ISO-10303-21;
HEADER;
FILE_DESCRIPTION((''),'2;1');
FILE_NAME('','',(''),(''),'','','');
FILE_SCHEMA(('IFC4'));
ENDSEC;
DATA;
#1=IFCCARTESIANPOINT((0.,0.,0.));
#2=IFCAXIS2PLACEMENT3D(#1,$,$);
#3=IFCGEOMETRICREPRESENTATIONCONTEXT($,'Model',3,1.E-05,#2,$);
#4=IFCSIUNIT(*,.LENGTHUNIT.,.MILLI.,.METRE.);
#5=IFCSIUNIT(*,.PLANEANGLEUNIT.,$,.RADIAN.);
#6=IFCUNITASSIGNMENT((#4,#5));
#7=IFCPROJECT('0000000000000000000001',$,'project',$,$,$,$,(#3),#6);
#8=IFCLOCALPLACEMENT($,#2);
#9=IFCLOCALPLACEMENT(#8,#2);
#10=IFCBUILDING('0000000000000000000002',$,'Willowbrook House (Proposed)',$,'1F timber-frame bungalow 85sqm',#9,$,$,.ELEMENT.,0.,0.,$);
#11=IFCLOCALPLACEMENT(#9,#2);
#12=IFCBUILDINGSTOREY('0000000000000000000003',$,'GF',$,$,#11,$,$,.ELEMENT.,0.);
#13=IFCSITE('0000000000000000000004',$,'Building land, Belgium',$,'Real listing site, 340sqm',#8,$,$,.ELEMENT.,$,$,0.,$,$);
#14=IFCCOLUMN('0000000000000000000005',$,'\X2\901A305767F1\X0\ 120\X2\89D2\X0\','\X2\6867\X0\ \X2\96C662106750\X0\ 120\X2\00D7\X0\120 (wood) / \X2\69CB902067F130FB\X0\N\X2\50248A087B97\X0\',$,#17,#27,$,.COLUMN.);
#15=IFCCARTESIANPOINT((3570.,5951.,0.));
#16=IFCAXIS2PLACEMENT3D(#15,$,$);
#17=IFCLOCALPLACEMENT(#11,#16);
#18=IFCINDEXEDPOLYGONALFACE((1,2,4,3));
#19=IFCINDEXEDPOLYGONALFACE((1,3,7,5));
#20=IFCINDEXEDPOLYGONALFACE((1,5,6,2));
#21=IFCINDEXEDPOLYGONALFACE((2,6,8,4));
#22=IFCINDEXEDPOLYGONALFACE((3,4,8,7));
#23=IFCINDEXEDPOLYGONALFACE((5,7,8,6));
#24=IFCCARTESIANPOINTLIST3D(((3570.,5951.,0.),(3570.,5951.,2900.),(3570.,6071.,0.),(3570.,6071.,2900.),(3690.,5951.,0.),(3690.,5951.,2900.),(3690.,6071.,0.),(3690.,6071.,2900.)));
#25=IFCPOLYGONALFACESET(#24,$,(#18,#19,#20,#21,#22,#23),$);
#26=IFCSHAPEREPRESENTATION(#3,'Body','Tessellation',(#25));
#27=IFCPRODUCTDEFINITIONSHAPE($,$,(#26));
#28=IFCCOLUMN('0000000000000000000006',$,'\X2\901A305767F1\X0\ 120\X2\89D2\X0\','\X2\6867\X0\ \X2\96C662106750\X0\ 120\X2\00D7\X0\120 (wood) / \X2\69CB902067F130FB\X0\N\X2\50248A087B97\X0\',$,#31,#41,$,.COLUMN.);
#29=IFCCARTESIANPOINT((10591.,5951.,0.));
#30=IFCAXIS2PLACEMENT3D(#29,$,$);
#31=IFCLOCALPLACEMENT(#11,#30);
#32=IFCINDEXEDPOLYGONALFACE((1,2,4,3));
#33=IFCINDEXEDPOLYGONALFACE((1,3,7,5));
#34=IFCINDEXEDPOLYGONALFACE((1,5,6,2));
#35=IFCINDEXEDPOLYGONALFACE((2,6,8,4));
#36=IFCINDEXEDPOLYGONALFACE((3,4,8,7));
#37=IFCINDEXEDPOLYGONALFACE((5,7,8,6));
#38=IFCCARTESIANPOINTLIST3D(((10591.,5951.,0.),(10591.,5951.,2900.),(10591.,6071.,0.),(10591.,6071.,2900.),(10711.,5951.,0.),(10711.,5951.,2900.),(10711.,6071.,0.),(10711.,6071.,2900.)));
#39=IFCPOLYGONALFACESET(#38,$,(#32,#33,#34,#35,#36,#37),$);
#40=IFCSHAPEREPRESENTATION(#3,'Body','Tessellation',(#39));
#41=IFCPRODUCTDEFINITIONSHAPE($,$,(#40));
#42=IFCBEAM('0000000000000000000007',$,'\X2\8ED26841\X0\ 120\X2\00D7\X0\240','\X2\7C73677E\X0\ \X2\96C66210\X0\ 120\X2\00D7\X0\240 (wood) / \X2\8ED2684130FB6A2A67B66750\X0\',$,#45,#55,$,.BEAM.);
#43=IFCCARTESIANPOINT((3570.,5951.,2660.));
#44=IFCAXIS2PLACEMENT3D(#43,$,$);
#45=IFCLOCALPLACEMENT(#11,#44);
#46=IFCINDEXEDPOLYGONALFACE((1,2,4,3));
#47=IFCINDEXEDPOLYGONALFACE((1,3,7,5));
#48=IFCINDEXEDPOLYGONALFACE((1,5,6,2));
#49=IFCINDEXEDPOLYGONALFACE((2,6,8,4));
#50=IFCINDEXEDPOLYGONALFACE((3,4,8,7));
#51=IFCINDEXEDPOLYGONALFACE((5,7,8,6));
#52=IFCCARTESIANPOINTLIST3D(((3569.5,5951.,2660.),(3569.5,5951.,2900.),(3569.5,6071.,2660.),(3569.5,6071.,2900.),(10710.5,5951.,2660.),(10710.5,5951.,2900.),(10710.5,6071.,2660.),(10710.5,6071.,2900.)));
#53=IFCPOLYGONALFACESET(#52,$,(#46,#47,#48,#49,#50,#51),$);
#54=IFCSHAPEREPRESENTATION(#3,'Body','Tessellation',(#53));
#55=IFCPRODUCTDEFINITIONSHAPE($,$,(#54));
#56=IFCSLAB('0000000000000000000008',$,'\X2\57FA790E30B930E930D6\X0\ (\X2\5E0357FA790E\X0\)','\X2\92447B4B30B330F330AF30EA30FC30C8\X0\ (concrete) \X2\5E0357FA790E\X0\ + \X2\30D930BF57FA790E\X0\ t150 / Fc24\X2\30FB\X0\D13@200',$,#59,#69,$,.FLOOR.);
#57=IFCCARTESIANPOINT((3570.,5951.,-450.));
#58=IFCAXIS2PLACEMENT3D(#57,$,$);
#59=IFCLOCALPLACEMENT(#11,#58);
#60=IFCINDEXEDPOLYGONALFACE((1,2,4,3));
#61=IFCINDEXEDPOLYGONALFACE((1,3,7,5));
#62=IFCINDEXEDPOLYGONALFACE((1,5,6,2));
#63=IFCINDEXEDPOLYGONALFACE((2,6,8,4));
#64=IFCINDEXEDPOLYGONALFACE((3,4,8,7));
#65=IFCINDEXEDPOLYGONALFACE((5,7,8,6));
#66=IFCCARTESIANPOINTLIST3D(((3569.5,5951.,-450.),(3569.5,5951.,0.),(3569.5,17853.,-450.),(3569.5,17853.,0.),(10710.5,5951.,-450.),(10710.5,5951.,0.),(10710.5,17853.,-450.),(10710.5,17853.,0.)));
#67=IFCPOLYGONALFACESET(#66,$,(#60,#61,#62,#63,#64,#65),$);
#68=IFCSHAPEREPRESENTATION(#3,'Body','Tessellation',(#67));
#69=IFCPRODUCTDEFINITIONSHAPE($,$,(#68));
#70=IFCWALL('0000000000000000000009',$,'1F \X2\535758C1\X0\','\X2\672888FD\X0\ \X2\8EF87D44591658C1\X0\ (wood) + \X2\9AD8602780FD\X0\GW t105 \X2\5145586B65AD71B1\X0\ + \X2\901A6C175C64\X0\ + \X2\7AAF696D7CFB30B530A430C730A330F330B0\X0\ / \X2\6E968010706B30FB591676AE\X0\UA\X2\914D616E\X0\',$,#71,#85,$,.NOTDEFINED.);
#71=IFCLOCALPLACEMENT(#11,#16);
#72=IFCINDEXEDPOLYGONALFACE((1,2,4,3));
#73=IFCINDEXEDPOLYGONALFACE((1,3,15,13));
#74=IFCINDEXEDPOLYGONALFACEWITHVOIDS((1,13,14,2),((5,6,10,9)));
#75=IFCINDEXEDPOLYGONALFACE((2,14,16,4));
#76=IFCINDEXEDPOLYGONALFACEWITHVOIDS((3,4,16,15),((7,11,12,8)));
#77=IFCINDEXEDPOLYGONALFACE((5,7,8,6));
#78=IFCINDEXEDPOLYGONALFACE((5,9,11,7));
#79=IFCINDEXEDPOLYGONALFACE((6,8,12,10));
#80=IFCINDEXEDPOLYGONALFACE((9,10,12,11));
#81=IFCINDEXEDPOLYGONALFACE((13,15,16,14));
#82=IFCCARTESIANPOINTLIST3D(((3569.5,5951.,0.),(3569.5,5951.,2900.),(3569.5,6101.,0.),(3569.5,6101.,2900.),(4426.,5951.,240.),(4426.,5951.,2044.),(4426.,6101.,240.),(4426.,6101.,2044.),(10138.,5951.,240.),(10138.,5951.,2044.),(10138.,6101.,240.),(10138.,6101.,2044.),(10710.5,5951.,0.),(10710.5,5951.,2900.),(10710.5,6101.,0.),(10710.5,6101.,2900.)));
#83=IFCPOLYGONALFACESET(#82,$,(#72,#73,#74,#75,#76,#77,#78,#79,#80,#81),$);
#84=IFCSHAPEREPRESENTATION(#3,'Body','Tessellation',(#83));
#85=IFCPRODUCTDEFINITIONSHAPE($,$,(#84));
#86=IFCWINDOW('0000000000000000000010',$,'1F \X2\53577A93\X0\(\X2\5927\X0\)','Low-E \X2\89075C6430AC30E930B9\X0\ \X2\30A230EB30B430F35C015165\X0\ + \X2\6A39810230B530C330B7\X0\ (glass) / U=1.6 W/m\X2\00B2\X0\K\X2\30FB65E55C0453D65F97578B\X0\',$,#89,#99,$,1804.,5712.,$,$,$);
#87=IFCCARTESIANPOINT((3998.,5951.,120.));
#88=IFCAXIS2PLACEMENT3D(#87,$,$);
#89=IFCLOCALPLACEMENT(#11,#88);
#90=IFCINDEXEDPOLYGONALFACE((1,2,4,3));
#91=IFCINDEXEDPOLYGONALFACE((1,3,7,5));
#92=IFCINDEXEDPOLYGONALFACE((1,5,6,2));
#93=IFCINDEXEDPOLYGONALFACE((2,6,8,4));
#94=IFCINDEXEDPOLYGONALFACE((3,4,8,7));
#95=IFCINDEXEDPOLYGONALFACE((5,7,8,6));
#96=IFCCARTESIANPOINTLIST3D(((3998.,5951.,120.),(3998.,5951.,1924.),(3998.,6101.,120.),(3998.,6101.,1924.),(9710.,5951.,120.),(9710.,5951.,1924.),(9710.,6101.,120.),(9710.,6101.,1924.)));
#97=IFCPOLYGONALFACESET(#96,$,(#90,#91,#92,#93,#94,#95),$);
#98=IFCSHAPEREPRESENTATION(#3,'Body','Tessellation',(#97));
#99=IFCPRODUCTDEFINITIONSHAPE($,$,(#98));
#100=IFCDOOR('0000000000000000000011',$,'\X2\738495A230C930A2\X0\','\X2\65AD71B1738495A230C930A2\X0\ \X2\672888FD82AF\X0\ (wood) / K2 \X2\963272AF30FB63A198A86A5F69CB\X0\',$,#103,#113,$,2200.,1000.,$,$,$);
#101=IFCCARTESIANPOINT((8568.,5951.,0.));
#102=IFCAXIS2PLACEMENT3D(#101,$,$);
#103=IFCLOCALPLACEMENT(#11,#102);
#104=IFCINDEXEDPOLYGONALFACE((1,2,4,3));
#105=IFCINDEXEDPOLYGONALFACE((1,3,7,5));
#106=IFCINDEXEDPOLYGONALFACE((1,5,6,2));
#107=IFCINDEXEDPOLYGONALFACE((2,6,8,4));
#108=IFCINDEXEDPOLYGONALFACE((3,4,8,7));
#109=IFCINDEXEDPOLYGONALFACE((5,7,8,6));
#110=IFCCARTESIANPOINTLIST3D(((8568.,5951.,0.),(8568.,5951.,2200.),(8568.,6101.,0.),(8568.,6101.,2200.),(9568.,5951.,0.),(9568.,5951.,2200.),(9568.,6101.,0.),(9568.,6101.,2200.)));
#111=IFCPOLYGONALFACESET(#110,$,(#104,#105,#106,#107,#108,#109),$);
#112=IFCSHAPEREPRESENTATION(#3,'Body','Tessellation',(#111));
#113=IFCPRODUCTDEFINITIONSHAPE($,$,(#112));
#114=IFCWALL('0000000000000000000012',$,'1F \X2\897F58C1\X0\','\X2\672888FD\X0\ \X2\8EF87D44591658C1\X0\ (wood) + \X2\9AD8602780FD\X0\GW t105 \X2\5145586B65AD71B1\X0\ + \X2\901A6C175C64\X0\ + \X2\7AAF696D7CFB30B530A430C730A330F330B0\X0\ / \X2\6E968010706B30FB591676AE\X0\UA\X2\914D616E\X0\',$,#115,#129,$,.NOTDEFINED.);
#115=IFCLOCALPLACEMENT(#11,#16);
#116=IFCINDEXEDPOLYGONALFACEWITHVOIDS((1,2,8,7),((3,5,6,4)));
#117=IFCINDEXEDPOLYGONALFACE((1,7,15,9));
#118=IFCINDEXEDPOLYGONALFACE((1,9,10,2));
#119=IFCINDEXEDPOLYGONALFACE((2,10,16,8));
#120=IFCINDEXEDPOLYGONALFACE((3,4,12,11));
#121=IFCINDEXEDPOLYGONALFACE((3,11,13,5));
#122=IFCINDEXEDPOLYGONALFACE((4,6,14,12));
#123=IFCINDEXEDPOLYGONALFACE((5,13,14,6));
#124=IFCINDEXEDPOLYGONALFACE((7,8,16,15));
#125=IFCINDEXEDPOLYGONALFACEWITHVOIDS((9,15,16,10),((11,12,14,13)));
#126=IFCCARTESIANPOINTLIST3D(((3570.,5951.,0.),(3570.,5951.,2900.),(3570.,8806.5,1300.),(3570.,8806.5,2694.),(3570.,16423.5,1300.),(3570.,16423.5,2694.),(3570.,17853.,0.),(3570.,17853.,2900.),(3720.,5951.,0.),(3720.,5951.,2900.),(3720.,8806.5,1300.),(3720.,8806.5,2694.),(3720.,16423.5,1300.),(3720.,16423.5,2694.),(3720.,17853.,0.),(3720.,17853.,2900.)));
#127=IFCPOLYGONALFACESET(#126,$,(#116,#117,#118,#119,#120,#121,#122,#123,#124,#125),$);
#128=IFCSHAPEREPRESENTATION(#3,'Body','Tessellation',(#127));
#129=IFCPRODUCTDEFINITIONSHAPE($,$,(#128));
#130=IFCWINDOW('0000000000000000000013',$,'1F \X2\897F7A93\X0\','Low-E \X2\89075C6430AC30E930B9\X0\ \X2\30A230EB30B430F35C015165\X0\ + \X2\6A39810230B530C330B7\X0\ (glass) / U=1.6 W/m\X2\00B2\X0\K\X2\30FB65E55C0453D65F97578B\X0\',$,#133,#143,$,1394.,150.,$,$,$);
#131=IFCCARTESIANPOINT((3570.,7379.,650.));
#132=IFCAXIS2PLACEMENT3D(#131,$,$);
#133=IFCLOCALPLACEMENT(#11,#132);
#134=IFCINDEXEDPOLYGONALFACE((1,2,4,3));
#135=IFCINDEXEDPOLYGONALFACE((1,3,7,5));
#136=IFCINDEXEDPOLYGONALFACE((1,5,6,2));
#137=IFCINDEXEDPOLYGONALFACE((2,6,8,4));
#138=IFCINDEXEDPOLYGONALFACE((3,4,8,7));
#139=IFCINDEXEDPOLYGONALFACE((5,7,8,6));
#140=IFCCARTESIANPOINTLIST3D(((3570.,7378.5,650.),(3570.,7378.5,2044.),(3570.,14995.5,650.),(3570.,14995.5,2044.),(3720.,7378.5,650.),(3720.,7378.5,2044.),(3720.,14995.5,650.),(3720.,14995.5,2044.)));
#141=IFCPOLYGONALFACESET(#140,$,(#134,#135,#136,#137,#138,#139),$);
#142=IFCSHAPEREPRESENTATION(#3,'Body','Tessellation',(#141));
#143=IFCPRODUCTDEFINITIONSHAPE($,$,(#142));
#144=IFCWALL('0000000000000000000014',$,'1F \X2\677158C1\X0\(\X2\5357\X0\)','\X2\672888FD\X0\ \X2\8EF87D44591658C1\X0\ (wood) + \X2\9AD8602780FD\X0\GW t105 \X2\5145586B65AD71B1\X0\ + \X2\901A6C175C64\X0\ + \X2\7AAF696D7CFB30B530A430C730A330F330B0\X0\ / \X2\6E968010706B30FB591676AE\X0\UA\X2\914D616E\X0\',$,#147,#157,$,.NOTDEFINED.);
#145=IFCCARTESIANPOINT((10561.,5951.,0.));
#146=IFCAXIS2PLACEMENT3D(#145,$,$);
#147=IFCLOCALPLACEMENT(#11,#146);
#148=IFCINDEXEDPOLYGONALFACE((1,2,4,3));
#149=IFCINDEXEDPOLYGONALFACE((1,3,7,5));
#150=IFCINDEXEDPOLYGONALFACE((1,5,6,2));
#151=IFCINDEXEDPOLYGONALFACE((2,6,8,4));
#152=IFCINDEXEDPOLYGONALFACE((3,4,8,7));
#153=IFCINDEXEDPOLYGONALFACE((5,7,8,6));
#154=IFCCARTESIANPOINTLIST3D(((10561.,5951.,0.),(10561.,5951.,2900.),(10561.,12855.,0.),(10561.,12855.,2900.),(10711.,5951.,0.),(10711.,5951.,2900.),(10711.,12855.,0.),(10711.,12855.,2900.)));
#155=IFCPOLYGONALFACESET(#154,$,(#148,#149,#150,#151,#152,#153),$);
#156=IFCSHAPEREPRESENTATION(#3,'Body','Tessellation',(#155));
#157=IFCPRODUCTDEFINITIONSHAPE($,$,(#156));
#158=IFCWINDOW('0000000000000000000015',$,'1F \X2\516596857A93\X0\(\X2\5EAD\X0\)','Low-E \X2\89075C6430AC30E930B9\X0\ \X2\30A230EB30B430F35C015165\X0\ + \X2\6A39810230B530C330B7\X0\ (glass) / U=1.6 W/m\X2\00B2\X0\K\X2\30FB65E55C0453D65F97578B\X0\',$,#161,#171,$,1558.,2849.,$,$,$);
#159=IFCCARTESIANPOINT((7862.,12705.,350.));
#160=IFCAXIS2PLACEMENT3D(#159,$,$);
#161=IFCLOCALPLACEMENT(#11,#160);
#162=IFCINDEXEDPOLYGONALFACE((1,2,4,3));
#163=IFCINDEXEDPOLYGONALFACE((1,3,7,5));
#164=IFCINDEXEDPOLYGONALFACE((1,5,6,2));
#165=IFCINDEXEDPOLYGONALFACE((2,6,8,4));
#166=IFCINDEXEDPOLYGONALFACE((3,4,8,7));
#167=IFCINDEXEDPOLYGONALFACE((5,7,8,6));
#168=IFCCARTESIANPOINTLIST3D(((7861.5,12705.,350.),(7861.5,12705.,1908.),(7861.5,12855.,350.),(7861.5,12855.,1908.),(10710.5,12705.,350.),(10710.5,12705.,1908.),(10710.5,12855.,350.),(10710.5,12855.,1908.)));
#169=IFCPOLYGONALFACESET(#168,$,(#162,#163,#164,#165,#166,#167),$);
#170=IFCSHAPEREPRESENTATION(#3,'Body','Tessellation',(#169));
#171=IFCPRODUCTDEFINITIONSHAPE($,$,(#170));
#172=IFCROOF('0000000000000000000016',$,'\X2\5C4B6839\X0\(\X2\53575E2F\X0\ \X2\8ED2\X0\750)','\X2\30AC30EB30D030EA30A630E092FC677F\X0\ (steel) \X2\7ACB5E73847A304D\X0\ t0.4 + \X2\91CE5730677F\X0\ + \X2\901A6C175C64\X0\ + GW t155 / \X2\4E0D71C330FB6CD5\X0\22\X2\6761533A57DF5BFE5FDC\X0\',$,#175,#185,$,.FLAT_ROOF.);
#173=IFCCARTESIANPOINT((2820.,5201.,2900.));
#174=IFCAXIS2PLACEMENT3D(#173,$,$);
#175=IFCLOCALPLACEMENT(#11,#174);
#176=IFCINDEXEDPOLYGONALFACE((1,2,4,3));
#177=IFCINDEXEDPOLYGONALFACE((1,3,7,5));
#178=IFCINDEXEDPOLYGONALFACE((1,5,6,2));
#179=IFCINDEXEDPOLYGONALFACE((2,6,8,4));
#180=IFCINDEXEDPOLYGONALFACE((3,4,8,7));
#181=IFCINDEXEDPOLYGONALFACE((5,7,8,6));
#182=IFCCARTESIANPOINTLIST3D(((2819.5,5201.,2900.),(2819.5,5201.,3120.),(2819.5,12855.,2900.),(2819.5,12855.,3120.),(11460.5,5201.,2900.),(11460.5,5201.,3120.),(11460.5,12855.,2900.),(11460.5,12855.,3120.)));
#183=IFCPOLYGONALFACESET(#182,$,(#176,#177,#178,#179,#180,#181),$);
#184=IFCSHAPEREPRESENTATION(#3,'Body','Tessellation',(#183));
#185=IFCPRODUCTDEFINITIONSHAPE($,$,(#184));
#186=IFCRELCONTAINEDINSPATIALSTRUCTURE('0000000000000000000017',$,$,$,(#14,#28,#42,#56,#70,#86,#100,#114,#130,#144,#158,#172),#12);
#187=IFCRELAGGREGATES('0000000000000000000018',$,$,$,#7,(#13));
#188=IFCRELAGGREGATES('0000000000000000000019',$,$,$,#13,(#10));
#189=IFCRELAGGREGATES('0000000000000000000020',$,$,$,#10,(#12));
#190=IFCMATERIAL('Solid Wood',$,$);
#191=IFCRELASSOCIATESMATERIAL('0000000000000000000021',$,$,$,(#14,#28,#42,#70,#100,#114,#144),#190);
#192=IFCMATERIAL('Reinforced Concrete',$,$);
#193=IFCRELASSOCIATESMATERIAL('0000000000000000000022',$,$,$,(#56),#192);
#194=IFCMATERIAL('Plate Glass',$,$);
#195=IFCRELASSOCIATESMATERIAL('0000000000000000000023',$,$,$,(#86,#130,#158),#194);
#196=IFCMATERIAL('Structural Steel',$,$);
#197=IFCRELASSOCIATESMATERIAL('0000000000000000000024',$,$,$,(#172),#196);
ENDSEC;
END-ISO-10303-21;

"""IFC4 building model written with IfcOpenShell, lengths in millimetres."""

from ifc_helpers import new_model, si_unit, frame, frame_2d, origin, place, context, project, spatial, rectangle, extrude, material, element, fill, save


model = new_model("IFC4")

# Units and contexts
model_context = context("Model", 3, precision=1e-05, world=origin())
ifc_project = project(units=[si_unit("LENGTHUNIT", "METRE", prefix="MILLI"), si_unit("PLANEANGLEUNIT", "RADIAN")], contexts=[model_context])

# Site, building, storey
site_placement = place(None, origin())
site = spatial("IfcSite", under=ifc_project, at=site_placement, Name="Building land, Belgium", ObjectType="Real listing site, 340sqm", CompositionType="ELEMENT", RefElevation=0.0)
building_placement = place(site_placement, origin())
building = spatial("IfcBuilding", under=site, at=building_placement, Name="Willowbrook House (Proposed)", ObjectType="1F timber-frame bungalow 85sqm", CompositionType="ELEMENT", ElevationOfRefHeight=0.0, ElevationOfTerrain=0.0)
storey_placement = place(building_placement, origin())
storey = spatial("IfcBuildingStorey", under=building, at=storey_placement, Name="GF", CompositionType="ELEMENT", Elevation=0.0)

# Columns
ifc_material_1 = material(Name="Solid Wood")
column_1_placement = place(storey_placement, frame((3570.0, 5951.0, 0.0)))
element("IfcColumn", 1, at=column_1_placement, inside=storey, material=ifc_material_1, Name="通し柱 120角", Description="桧 集成材 120×120 (wood) / 構造柱・N値計算", PredefinedType="COLUMN", context=model_context, shape_type="SweptSolid", body=[
    extrude(rectangle(XDim=120.0, YDim=120.0, at=frame_2d((60.0, 60.0))), frame((3570.0, 5951.0, 0.0)), (0.0, 0.0, 1.0), 2900.0),
])
column_2_placement = place(storey_placement, frame((10591.0, 5951.0, 0.0)))
element("IfcColumn", 2, at=column_2_placement, inside=storey, material=ifc_material_1, Name="通し柱 120角", Description="桧 集成材 120×120 (wood) / 構造柱・N値計算", PredefinedType="COLUMN", context=model_context, shape_type="SweptSolid", body=[
    extrude(rectangle(XDim=120.0, YDim=120.0, at=frame_2d((60.0, 60.0))), frame((10591.0, 5951.0, 0.0)), (0.0, 0.0, 1.0), 2900.0),
])

# Beam
beam_1_placement = place(storey_placement, frame((3570.0, 5951.0, 2660.0)))
element("IfcBeam", 3, at=beam_1_placement, inside=storey, material=ifc_material_1, Name="軒桁 120×240", Description="米松 集成 120×240 (wood) / 軒桁・横架材", PredefinedType="BEAM", context=model_context, shape_type="SweptSolid", body=[
    extrude(rectangle(XDim=7141.0, YDim=120.0, at=frame_2d((3570.0, 60.0))), frame((3570.0, 5951.0, 2660.0)), (0.0, 0.0, 1.0), 240.0),
])

# Slab
ifc_material_2 = material(Name="Reinforced Concrete")
slab_1_placement = place(storey_placement, frame((3570.0, 5951.0, -450.0)))
element("IfcSlab", 4, at=slab_1_placement, inside=storey, material=ifc_material_2, Name="基礎スラブ (布基礎)", Description="鉄筋コンクリート (concrete) 布基礎 + ベタ基礎 t150 / Fc24・D13@200", PredefinedType="FLOOR", context=model_context, shape_type="SweptSolid", body=[
    extrude(rectangle(XDim=7141.0, YDim=11902.0, at=frame_2d((3570.0, 5951.0))), frame((3570.0, 5951.0, -450.0)), (0.0, 0.0, 1.0), 450.0),
])

# Wall, openings, window, door
wall_1_placement = place(storey_placement, frame((3570.0, 5951.0, 0.0)))
wall_1 = element("IfcWall", 5, at=wall_1_placement, inside=storey, material=ifc_material_1, Name="1F 南壁", Description="木製 軸組外壁 (wood) + 高性能GW t105 充填断熱 + 通気層 + 窯業系サイディング / 準耐火・外皮UA配慮", PredefinedType="NOTDEFINED", context=model_context, shape_type="SweptSolid", body=[
    extrude(rectangle(XDim=7141.0, YDim=150.0, at=frame_2d((3570.0, 75.0))), frame((3570.0, 5951.0, 0.0)), (0.0, 0.0, 1.0), 2900.0),
])
opening_1_placement = place(storey_placement, frame((3998.0, 5951.0, 120.0)))
opening_1 = element("IfcOpeningElement", 6, at=opening_1_placement, cuts=wall_1, PredefinedType="NOTDEFINED", context=model_context, shape_type="SweptSolid", body=[
    extrude(rectangle(XDim=5712.0, YDim=150.0, at=frame_2d((2856.0, 75.0))), frame((3998.0, 5951.0, 120.0)), (0.0, 0.0, 1.0), 1804.0),
])
opening_2_placement = place(storey_placement, frame((8568.0, 5951.0, 0.0)))
opening_2 = element("IfcOpeningElement", 7, at=opening_2_placement, cuts=wall_1, PredefinedType="NOTDEFINED", context=model_context, shape_type="SweptSolid", body=[
    extrude(rectangle(XDim=1000.0, YDim=150.0, at=frame_2d((500.0, 75.0))), frame((8568.0, 5951.0, 0.0)), (0.0, 0.0, 1.0), 2200.0),
])
ifc_material_3 = material(Name="Plate Glass")
window_1_placement = place(storey_placement, frame((3998.0, 5951.0, 120.0)))
window_1 = element("IfcWindow", 8, at=window_1_placement, inside=storey, material=ifc_material_3, Name="1F 南窓(大)", Description="Low-E 複層ガラス アルゴン封入 + 樹脂サッシ (glass) / U=1.6 W/m²K・日射取得型", OverallHeight=1804.0, OverallWidth=5712.0, context=model_context, shape_type="SweptSolid", body=[
    extrude(rectangle(XDim=5712.0, YDim=150.0, at=frame_2d((2856.0, 75.0))), frame((3998.0, 5951.0, 120.0)), (0.0, 0.0, 1.0), 1804.0),
])
fill(opening_1, window_1)
door_1_placement = place(storey_placement, frame((8568.0, 5951.0, 0.0)))
door_1 = element("IfcDoor", 9, at=door_1_placement, inside=storey, material=ifc_material_1, Name="玄関ドア", Description="断熱玄関ドア 木製芯 (wood) / K2 防犯・採風機構", OverallHeight=2200.0, OverallWidth=1000.0, context=model_context, shape_type="SweptSolid", body=[
    extrude(rectangle(XDim=1000.0, YDim=150.0, at=frame_2d((500.0, 75.0))), frame((8568.0, 5951.0, 0.0)), (0.0, 0.0, 1.0), 2200.0),
])
fill(opening_2, door_1)

# Walls, openings, windows
wall_2_placement = place(storey_placement, frame((3570.0, 5951.0, 0.0)))
wall_2 = element("IfcWall", 10, at=wall_2_placement, inside=storey, material=ifc_material_1, Name="1F 西壁", Description="木製 軸組外壁 (wood) + 高性能GW t105 充填断熱 + 通気層 + 窯業系サイディング / 準耐火・外皮UA配慮", PredefinedType="NOTDEFINED", context=model_context, shape_type="SweptSolid", body=[
    extrude(rectangle(XDim=150.0, YDim=11902.0, at=frame_2d((75.0, 5951.0))), frame((3570.0, 5951.0, 0.0)), (0.0, 0.0, 1.0), 2900.0),
])
opening_3_placement = place(storey_placement, frame((3570.0, 7379.0, 650.0)))
opening_3 = element("IfcOpeningElement", 11, at=opening_3_placement, cuts=wall_2, PredefinedType="NOTDEFINED", context=model_context, shape_type="SweptSolid", body=[
    extrude(rectangle(XDim=150.0, YDim=7617.0, at=frame_2d((75.0, 3808.0))), frame((3570.0, 7379.0, 650.0)), (0.0, 0.0, 1.0), 1394.0),
])
window_2_placement = place(storey_placement, frame((3570.0, 7379.0, 650.0)))
window_2 = element("IfcWindow", 12, at=window_2_placement, inside=storey, material=ifc_material_3, Name="1F 西窓", Description="Low-E 複層ガラス アルゴン封入 + 樹脂サッシ (glass) / U=1.6 W/m²K・日射取得型", OverallHeight=1394.0, OverallWidth=150.0, context=model_context, shape_type="SweptSolid", body=[
    extrude(rectangle(XDim=150.0, YDim=7617.0, at=frame_2d((75.0, 3808.0))), frame((3570.0, 7379.0, 650.0)), (0.0, 0.0, 1.0), 1394.0),
])
fill(opening_3, window_2)
wall_3_placement = place(storey_placement, frame((10561.0, 5951.0, 0.0)))
wall_3 = element("IfcWall", 13, at=wall_3_placement, inside=storey, material=ifc_material_1, Name="1F 東壁(南)", Description="木製 軸組外壁 (wood) + 高性能GW t105 充填断熱 + 通気層 + 窯業系サイディング / 準耐火・外皮UA配慮", PredefinedType="NOTDEFINED", context=model_context, shape_type="SweptSolid", body=[
    extrude(rectangle(XDim=150.0, YDim=6904.0, at=frame_2d((75.0, 3452.0))), frame((10561.0, 5951.0, 0.0)), (0.0, 0.0, 1.0), 2900.0),
])
opening_4_placement = place(storey_placement, frame((7862.0, 12705.0, 350.0)))
opening_4 = element("IfcOpeningElement", 14, at=opening_4_placement, cuts=wall_3, PredefinedType="NOTDEFINED", context=model_context, shape_type="SweptSolid", body=[
    extrude(rectangle(XDim=2849.0, YDim=150.0, at=frame_2d((1424.0, 75.0))), frame((7862.0, 12705.0, 350.0)), (0.0, 0.0, 1.0), 1558.0),
])
window_3_placement = place(storey_placement, frame((7862.0, 12705.0, 350.0)))
window_3 = element("IfcWindow", 15, at=window_3_placement, inside=storey, material=ifc_material_3, Name="1F 入隅窓(庭)", Description="Low-E 複層ガラス アルゴン封入 + 樹脂サッシ (glass) / U=1.6 W/m²K・日射取得型", OverallHeight=1558.0, OverallWidth=2849.0, context=model_context, shape_type="SweptSolid", body=[
    extrude(rectangle(XDim=2849.0, YDim=150.0, at=frame_2d((1424.0, 75.0))), frame((7862.0, 12705.0, 350.0)), (0.0, 0.0, 1.0), 1558.0),
])
fill(opening_4, window_3)

# Roof
ifc_material_4 = material(Name="Structural Steel")
roof_placement = place(storey_placement, frame((2820.0, 5201.0, 2900.0)))
element("IfcRoof", 16, at=roof_placement, inside=storey, material=ifc_material_4, Name="屋根(南帯 軒750)", Description="ガルバリウム鋼板 (steel) 立平葺き t0.4 + 野地板 + 通気層 + GW t155 / 不燃・法22条区域対応", PredefinedType="FLAT_ROOF", context=model_context, shape_type="SweptSolid", body=[
    extrude(rectangle(XDim=8641.0, YDim=7654.0, at=frame_2d((4320.0, 3827.0))), frame((2820.0, 5201.0, 2900.0)), (0.0, 0.0, 1.0), 220.0),
])

save(model, "model.ifc")
